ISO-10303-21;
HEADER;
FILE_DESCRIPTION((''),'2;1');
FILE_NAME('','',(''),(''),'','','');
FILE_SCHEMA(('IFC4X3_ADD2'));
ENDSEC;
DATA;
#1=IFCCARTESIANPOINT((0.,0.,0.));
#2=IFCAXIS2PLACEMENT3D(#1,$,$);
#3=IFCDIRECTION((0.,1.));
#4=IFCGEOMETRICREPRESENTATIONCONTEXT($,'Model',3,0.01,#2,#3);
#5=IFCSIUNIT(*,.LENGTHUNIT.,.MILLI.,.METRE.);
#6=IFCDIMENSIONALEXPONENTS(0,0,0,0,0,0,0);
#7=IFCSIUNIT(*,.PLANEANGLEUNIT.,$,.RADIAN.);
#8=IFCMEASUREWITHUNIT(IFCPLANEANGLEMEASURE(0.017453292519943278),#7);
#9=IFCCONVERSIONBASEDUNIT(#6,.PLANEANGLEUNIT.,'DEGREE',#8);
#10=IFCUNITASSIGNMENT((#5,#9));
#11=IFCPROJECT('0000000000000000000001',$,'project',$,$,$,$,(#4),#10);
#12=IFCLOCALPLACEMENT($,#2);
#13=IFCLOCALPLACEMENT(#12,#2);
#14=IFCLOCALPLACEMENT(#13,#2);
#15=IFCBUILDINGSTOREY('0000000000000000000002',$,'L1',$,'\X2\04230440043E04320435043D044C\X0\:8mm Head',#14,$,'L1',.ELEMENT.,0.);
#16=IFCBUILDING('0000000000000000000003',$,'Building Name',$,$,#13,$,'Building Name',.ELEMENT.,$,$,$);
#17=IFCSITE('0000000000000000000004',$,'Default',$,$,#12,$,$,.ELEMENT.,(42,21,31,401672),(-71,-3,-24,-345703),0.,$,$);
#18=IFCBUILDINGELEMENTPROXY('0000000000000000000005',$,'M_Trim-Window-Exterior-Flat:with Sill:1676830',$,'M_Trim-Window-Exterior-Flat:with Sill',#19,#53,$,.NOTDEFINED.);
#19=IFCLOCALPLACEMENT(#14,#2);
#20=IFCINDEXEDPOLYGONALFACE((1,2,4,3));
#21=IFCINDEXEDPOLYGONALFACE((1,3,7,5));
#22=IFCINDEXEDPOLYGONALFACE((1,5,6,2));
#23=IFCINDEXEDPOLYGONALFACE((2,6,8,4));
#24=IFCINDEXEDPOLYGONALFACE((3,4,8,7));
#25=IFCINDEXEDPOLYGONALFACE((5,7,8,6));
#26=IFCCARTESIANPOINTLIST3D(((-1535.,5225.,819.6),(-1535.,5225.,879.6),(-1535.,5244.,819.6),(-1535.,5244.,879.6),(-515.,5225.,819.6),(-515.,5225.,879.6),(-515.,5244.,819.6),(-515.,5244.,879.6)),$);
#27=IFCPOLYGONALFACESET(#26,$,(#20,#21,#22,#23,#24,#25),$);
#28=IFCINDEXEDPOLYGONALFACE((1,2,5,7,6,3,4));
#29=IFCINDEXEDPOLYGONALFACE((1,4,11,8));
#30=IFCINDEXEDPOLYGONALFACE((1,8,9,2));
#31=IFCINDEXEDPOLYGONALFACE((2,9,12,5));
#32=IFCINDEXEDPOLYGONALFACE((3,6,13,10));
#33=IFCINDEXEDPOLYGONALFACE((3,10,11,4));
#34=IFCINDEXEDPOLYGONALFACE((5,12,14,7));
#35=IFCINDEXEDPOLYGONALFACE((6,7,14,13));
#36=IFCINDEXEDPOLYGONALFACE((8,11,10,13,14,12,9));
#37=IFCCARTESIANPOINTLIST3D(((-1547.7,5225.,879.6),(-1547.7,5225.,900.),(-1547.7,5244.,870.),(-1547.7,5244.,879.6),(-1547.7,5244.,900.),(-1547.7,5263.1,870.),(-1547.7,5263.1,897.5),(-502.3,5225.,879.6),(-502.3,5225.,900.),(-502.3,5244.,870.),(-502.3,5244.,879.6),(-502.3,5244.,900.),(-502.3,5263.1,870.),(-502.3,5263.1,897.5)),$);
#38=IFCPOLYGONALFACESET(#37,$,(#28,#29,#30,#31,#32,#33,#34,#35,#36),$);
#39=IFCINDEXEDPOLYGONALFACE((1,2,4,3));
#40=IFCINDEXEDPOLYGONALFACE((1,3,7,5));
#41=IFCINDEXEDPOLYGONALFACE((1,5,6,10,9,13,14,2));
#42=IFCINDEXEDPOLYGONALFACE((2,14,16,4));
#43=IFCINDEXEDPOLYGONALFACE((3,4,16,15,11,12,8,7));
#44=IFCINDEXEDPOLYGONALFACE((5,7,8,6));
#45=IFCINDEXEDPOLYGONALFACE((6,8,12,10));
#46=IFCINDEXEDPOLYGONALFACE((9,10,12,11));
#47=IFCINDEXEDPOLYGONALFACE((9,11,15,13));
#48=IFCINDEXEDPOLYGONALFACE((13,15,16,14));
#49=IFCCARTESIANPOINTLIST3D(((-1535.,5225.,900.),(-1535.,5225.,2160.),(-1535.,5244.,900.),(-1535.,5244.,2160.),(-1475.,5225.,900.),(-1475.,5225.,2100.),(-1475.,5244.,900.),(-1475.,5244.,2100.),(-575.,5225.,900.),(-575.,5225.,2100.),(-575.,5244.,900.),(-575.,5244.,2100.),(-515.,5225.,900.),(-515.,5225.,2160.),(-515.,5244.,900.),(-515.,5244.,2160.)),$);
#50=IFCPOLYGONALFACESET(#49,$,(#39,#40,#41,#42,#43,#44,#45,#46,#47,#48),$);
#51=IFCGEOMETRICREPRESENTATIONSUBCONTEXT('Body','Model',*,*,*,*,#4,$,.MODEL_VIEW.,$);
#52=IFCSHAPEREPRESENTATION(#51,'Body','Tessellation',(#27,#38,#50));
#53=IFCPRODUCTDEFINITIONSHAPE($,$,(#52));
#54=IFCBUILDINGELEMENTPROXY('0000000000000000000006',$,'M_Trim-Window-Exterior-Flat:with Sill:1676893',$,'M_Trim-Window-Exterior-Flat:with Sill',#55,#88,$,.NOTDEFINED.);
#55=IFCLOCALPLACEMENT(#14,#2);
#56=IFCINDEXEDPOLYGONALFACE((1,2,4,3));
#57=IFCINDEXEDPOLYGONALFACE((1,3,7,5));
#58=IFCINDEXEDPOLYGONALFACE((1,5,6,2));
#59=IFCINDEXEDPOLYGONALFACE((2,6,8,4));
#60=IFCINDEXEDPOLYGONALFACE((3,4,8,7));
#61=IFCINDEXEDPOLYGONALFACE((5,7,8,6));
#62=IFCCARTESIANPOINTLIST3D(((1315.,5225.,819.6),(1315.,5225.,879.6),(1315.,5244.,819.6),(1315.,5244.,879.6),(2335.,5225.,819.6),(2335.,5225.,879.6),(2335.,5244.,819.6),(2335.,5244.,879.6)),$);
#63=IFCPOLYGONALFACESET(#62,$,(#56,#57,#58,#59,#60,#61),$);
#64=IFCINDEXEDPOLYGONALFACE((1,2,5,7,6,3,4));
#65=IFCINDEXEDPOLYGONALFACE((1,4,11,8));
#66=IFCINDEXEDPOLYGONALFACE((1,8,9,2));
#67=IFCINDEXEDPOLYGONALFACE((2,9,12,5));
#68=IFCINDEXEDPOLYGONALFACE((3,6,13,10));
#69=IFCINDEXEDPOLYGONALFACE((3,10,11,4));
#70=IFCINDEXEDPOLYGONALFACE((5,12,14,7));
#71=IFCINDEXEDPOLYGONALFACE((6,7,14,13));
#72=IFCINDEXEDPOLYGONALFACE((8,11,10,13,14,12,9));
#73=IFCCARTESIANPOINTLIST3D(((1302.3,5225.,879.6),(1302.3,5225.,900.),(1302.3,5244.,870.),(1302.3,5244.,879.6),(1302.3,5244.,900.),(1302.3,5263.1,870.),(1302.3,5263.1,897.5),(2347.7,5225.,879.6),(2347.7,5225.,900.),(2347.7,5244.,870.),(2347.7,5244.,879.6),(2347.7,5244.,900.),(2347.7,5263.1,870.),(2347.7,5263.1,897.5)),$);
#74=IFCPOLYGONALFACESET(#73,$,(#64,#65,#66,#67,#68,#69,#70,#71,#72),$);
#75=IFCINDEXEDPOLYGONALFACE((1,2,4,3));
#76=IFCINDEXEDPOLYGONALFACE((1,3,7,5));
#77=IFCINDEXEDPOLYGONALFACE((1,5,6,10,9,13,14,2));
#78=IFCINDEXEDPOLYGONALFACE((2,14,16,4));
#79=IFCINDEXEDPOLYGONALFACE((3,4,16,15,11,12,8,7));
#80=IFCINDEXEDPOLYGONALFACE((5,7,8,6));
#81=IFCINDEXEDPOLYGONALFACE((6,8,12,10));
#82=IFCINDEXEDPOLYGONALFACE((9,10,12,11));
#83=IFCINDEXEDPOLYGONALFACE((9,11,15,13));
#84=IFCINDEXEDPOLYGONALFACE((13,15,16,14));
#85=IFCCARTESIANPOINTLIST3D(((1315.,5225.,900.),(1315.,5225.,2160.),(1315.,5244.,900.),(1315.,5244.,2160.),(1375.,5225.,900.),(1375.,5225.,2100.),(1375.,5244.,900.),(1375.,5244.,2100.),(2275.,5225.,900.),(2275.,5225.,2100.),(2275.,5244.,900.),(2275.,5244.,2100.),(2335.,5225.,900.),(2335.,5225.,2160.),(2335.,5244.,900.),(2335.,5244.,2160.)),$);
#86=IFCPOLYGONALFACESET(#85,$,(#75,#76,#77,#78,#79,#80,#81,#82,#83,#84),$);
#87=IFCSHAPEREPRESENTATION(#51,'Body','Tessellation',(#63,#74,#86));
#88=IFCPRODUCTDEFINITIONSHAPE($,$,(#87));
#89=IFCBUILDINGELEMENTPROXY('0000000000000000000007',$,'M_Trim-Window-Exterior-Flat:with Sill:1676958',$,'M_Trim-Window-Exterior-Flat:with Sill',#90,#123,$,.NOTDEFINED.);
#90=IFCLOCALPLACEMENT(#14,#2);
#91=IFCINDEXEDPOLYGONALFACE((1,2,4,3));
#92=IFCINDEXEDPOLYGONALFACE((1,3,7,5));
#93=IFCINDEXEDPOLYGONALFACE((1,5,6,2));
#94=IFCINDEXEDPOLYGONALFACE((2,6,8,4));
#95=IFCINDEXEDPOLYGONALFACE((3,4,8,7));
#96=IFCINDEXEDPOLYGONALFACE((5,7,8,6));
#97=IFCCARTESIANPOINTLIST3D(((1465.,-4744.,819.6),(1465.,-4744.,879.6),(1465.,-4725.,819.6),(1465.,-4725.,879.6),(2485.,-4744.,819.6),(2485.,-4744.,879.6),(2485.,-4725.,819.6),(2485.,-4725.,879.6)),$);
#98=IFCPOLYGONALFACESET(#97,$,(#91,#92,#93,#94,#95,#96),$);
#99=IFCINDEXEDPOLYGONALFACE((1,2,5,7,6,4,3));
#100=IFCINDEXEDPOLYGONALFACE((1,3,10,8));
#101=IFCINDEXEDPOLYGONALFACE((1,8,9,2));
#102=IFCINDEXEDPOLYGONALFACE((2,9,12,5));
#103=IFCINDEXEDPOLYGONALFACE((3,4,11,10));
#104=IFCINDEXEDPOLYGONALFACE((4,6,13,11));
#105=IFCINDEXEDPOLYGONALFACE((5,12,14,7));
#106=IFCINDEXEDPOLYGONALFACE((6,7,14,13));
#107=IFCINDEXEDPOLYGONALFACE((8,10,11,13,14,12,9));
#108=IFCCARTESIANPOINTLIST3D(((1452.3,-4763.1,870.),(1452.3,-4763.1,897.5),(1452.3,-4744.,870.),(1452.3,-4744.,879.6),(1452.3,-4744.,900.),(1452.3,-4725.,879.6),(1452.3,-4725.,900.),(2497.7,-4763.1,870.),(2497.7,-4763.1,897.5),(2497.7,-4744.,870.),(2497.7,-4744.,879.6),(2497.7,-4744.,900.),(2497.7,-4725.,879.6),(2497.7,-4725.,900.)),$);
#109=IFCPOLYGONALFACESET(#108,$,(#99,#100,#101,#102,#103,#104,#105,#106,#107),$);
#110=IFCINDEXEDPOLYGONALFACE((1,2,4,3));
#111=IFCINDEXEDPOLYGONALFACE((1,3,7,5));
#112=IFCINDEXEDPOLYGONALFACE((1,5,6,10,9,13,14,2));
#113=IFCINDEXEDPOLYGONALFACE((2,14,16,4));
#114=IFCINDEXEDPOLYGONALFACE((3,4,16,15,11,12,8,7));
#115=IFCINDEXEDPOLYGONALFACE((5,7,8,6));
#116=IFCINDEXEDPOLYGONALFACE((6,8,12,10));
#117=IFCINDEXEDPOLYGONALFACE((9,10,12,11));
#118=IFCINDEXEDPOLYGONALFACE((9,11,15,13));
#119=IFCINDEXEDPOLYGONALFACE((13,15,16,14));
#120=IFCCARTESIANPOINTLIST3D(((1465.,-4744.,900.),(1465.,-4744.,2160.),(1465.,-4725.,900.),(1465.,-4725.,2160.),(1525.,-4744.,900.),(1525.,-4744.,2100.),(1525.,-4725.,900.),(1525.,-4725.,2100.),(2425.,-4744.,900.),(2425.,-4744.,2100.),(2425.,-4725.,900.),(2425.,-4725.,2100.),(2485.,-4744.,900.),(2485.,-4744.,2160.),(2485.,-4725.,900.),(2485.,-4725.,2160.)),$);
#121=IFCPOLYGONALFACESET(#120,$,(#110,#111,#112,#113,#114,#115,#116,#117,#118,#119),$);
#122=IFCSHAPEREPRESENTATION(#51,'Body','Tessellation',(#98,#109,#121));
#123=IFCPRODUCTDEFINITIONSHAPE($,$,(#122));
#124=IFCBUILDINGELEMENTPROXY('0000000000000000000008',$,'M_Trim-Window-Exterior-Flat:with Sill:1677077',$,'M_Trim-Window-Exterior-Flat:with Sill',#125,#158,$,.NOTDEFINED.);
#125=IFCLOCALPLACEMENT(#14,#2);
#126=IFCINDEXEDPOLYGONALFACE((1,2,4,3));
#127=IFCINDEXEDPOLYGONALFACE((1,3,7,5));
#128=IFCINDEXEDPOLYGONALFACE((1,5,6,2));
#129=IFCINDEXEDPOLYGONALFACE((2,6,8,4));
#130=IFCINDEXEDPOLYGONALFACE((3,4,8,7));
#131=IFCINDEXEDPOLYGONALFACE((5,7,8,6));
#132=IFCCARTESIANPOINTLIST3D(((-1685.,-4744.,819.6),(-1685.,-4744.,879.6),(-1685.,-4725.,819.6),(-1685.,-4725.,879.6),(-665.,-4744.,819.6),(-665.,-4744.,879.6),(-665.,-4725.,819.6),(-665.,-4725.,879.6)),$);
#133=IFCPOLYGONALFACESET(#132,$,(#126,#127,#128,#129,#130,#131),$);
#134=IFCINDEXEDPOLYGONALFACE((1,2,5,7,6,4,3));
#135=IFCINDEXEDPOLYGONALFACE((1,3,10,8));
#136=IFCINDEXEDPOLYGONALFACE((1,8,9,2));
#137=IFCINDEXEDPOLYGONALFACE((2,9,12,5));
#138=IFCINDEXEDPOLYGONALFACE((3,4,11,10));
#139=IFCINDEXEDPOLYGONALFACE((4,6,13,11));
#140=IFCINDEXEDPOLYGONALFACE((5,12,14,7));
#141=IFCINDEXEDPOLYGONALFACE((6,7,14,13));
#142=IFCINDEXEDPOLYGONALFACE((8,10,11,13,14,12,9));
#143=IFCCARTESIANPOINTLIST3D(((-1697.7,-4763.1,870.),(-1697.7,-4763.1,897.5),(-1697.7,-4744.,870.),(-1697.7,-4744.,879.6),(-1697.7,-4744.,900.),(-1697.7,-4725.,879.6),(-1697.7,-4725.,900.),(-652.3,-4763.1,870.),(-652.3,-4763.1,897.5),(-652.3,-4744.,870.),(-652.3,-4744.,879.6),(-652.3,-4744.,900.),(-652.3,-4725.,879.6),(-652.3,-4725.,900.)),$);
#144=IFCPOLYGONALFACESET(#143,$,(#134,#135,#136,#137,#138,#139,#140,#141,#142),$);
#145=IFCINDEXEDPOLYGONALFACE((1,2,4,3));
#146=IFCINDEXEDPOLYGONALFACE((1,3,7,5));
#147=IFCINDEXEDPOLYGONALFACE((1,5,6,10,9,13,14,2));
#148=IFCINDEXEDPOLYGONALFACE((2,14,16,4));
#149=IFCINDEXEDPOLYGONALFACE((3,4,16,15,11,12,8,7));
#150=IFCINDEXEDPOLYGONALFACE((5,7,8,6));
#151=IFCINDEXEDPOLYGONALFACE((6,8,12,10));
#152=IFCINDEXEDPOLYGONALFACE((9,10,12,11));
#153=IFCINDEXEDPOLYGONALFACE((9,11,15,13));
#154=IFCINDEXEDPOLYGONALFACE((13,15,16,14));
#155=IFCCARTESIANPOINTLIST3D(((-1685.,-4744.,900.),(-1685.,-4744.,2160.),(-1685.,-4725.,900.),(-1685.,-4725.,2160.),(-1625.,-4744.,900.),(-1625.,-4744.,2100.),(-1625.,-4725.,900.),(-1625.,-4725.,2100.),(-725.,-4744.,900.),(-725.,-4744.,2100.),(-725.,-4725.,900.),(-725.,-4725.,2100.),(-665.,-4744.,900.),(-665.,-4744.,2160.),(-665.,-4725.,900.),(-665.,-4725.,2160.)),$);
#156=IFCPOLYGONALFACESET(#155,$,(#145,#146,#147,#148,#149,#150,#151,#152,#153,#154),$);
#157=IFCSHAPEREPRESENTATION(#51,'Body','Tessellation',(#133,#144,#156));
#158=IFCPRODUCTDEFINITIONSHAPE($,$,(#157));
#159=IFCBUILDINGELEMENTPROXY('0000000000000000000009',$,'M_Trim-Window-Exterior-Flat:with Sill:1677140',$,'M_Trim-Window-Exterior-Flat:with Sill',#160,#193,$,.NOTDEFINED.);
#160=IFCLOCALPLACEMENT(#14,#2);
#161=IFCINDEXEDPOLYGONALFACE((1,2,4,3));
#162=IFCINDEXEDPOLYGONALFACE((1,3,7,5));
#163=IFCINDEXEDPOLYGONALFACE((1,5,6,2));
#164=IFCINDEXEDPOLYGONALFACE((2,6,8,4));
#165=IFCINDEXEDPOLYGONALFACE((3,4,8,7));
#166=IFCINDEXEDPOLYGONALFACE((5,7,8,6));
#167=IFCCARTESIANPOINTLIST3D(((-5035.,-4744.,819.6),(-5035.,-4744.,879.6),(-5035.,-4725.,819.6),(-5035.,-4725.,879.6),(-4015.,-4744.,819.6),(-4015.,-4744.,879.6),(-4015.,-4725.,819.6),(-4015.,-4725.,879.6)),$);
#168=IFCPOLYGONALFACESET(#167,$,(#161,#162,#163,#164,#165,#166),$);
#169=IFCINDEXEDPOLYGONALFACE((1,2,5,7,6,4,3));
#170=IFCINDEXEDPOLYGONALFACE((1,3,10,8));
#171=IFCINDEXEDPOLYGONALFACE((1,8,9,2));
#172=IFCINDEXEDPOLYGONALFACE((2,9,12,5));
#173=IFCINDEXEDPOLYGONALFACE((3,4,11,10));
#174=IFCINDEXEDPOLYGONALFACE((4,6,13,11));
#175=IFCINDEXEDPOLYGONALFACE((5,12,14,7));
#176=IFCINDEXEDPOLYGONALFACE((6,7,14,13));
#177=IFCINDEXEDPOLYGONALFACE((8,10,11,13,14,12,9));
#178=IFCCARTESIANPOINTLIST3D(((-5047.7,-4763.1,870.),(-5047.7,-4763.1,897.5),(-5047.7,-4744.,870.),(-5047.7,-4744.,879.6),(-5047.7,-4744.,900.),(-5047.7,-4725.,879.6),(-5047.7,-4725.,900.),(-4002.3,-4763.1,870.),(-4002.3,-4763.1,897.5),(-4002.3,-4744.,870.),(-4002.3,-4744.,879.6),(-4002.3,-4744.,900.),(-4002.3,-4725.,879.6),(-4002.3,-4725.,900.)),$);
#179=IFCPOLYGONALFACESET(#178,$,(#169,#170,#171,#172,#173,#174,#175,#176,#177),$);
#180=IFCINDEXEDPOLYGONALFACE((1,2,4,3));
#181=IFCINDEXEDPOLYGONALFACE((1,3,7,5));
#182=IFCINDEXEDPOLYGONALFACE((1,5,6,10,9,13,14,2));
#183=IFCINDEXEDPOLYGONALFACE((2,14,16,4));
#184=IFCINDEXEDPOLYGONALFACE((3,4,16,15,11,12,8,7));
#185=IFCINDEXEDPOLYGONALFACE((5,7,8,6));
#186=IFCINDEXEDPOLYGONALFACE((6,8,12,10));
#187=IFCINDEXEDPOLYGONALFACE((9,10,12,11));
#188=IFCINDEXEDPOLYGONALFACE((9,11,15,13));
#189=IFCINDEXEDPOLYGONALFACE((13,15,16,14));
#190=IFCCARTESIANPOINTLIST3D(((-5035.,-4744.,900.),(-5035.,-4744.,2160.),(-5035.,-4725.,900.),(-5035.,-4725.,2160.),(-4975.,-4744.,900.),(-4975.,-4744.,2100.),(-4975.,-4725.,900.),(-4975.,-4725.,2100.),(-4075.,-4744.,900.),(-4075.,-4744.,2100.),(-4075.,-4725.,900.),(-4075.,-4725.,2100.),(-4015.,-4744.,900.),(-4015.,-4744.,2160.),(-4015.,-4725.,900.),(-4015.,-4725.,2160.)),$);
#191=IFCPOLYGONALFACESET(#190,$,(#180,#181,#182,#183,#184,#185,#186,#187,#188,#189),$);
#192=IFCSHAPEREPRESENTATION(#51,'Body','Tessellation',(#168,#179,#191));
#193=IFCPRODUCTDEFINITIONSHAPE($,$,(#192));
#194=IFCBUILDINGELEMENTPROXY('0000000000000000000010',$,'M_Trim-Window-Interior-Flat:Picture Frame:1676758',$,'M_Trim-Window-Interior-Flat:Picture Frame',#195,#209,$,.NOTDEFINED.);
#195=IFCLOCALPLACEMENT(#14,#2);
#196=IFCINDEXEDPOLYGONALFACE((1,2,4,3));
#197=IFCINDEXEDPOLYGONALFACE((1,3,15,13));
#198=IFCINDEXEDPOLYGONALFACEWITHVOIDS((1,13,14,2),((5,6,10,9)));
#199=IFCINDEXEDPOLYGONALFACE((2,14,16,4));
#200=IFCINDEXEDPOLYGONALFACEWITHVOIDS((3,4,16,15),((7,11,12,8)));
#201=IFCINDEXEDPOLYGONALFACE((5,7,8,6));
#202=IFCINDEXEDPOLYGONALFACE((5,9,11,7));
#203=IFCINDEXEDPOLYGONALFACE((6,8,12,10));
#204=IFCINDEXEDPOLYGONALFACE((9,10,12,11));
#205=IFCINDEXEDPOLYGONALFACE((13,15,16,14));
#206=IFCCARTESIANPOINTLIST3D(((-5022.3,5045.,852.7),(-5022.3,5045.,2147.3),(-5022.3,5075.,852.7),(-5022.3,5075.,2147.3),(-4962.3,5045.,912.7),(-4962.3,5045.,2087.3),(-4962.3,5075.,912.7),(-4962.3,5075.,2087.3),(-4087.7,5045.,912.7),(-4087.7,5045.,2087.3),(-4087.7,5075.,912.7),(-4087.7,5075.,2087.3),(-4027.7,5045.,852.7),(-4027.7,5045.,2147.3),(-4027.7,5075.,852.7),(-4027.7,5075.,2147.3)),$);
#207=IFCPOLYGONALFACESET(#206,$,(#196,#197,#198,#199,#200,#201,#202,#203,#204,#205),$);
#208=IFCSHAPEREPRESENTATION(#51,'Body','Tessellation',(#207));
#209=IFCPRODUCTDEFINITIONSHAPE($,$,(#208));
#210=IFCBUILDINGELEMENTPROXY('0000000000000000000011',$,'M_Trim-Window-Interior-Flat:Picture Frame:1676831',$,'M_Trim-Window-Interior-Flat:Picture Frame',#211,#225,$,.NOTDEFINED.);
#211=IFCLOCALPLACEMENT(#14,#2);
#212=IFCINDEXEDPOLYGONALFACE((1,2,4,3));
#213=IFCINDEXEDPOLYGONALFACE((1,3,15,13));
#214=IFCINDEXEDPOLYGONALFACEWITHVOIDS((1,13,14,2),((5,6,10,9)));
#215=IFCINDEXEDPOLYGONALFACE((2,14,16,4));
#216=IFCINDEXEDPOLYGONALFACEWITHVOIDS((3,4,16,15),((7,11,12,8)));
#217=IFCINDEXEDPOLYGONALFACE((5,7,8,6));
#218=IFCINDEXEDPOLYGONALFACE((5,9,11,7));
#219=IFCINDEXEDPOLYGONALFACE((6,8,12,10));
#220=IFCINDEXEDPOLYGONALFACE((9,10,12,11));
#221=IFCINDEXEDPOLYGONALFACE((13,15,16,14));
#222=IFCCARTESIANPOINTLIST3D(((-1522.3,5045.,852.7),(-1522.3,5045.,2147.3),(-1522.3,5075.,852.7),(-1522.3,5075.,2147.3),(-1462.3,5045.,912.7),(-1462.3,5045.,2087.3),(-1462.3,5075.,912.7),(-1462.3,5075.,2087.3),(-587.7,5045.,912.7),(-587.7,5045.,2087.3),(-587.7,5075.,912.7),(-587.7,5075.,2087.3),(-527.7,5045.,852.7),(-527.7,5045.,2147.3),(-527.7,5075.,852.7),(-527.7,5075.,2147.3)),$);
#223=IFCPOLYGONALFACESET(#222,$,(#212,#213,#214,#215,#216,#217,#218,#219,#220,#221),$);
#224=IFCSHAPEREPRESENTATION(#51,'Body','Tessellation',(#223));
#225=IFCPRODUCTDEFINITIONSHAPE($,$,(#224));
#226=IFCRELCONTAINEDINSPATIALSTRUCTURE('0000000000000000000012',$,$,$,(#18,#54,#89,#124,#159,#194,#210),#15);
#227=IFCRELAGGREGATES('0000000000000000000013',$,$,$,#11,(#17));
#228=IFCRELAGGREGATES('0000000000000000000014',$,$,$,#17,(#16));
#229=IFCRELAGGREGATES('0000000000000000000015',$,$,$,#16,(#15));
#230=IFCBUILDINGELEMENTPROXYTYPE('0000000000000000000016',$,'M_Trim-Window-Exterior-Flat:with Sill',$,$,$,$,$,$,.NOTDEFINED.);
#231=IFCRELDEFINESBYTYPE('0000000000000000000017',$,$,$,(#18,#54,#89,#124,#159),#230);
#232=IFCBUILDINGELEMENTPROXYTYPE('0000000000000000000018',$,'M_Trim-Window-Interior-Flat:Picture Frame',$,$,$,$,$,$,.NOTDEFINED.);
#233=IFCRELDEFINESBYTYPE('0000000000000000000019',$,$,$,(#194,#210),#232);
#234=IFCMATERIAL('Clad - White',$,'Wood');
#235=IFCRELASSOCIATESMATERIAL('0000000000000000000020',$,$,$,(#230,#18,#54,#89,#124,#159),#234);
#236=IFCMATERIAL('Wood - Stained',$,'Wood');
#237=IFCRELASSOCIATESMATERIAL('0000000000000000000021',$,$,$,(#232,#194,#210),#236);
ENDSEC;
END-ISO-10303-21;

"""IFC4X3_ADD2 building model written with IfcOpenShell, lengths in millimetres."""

from ifc_helpers import new_model, entity, si_unit, converted_unit, direction, frame, frame_2d, origin, place, context, subcontext, project, spatial, polyline, rectangle, outline, extrude, source, transform, mapped, material, type_object, type_shapes, element, save


model = new_model("IFC4X3_ADD2")

# Units and contexts
model_context = context("Model", 3, precision=0.01, world=origin(), true_north=direction((0.0, 1.0)))
body_context = subcontext(model_context, "Body", "Model", "MODEL_VIEW")
ifc_project = project(units=[si_unit("LENGTHUNIT", "METRE", prefix="MILLI"), converted_unit("PLANEANGLEUNIT", "DEGREE", entity("IfcPlaneAngleMeasure", 0.017453292519943278), si_unit("PLANEANGLEUNIT", "RADIAN"), dimensions=[0, 0, 0, 0, 0, 0, 0])], contexts=[model_context])

# Site, building, storey
site_placement = place(None, origin())
site = spatial("IfcSite", under=ifc_project, at=site_placement, Name="Default", CompositionType="ELEMENT", RefLatitude=(42, 21, 31, 401672), RefLongitude=(-71, -3, -24, -345703), RefElevation=0.0)
building_placement = place(site_placement, origin())
building = spatial("IfcBuilding", under=site, at=building_placement, Name="Building Name", LongName="Building Name", CompositionType="ELEMENT")
storey_placement = place(building_placement, origin())
storey = spatial("IfcBuildingStorey", under=building, at=storey_placement, Name="L1", ObjectType="Уровень:8mm Head", LongName="L1", CompositionType="ELEMENT", Elevation=0.0)

# Building element proxies
ifc_material_1 = material(Name="Clad - White", Category="Wood")
ifc_material_2 = material(Name="Wood - Stained", Category="Wood")
building_element_proxy_type_1 = type_object("IfcBuildingElementProxyType", Name="M_Trim-Window-Exterior-Flat:with Sill", PredefinedType="NOTDEFINED", material=ifc_material_1)
shared_shape_1 = source(origin(), body_context, "Body", "SweptSolid", [
    extrude(rectangle(XDim=1020.0, YDim=60.0, at=frame_2d((0.0, 0.0), x_axis=(1.0, 0.0))), frame((0.0, -1250.4, 0.0), z_axis=(0.0, 0.0, 1.0), x_axis=(-1.0, 0.0, 0.0)), (0.0, 0.0, 1.0), 19.0),
    extrude(outline(polyline([(-19.0, -15.2), (0.0, -15.2), (0.0, -5.7), (19.0, -5.7), (19.0, 14.8), (0.0, 14.8), (-19.0, 12.3), (-19.0, -15.2)])), frame((-522.7, -1214.8, 19.0), z_axis=(1.0, 0.0, 0.0), x_axis=(0.0, 0.0, -1.0)), (0.0, 0.0, 1.0), 1045.4),
    extrude(outline(polyline([(-645.0, -510.0), (615.0, -510.0), (615.0, -450.0), (-585.0, -450.0), (-585.0, 450.0), (615.0, 450.0), (615.0, 510.0), (-645.0, 510.0), (-645.0, -510.0)])), frame((0.0, -585.0, 0.0), z_axis=(0.0, 0.0, 1.0), x_axis=(0.0, -1.0, 0.0)), (0.0, 0.0, 1.0), 19.0),
])
type_shapes(building_element_proxy_type_1, [shared_shape_1])
for number, where, z_axis, x_axis, name in (
    (1, (-1025.0, 5225.0, 2100.0), (0.0, 1.0, 0.0), (-1.0, 0.0, 0.0), "M_Trim-Window-Exterior-Flat:with Sill:1676830"),
    (2, (1825.0, 5225.0, 2100.0), (0.0, 1.0, 0.0), (-1.0, 0.0, 0.0), "M_Trim-Window-Exterior-Flat:with Sill:1676893"),
    (3, (1975.0, -4725.0, 2100.0), (0.0, -1.0, 0.0), (1.0, 0.0, 0.0), "M_Trim-Window-Exterior-Flat:with Sill:1676958"),
    (4, (-1175.0, -4725.0, 2100.0), (0.0, -1.0, 0.0), (1.0, 0.0, 0.0), "M_Trim-Window-Exterior-Flat:with Sill:1677077"),
    (5, (-4525.0, -4725.0, 2100.0), (0.0, -1.0, 0.0), (1.0, 0.0, 0.0), "M_Trim-Window-Exterior-Flat:with Sill:1677140"),
):
    element("IfcBuildingElementProxy", number, at=place(storey_placement, frame(where, z_axis=z_axis, x_axis=x_axis)), inside=storey, type_object=building_element_proxy_type_1, material=ifc_material_1, Name=name, ObjectType="M_Trim-Window-Exterior-Flat:with Sill", PredefinedType="NOTDEFINED", context=body_context, shape_type="MappedRepresentation", body=[
        mapped(shared_shape_1, transform((0.0, 0.0, 0.0), scale=1.0)),
    ])
building_element_proxy_type_2 = type_object("IfcBuildingElementProxyType", Name="M_Trim-Window-Interior-Flat:Picture Frame", PredefinedType="NOTDEFINED", material=ifc_material_2)
shared_shape_2 = source(origin(), body_context, "Body", "SweptSolid", [
    extrude(outline(polyline([(-497.3, -647.3), (497.3, -647.3), (497.3, 647.3), (-497.3, 647.3), (-497.3, -647.3)]), holes=[polyline([(-437.3, -587.3), (-437.3, 587.3), (437.3, 587.3), (437.3, -587.3), (-437.3, -587.3)])]), frame((0.0, -600.0, 0.0), z_axis=(0.0, 0.0, 1.0), x_axis=(-1.0, 0.0, 0.0)), (0.0, 0.0, 1.0), 30.0),
])
type_shapes(building_element_proxy_type_2, [shared_shape_2])
for number, where, z_axis, x_axis, name in (
    (6, (-4525.0, 5075.0, 2100.0), (0.0, -1.0, 0.0), (1.0, 0.0, 0.0), "M_Trim-Window-Interior-Flat:Picture Frame:1676758"),
    (7, (-1025.0, 5075.0, 2100.0), (0.0, -1.0, 0.0), (1.0, 0.0, 0.0), "M_Trim-Window-Interior-Flat:Picture Frame:1676831"),
):
    element("IfcBuildingElementProxy", number, at=place(storey_placement, frame(where, z_axis=z_axis, x_axis=x_axis)), inside=storey, type_object=building_element_proxy_type_2, material=ifc_material_2, Name=name, ObjectType="M_Trim-Window-Interior-Flat:Picture Frame", PredefinedType="NOTDEFINED", context=body_context, shape_type="MappedRepresentation", body=[
        mapped(shared_shape_2, transform((0.0, 0.0, 0.0), scale=1.0)),
    ])

save(model, "model.ifc")
